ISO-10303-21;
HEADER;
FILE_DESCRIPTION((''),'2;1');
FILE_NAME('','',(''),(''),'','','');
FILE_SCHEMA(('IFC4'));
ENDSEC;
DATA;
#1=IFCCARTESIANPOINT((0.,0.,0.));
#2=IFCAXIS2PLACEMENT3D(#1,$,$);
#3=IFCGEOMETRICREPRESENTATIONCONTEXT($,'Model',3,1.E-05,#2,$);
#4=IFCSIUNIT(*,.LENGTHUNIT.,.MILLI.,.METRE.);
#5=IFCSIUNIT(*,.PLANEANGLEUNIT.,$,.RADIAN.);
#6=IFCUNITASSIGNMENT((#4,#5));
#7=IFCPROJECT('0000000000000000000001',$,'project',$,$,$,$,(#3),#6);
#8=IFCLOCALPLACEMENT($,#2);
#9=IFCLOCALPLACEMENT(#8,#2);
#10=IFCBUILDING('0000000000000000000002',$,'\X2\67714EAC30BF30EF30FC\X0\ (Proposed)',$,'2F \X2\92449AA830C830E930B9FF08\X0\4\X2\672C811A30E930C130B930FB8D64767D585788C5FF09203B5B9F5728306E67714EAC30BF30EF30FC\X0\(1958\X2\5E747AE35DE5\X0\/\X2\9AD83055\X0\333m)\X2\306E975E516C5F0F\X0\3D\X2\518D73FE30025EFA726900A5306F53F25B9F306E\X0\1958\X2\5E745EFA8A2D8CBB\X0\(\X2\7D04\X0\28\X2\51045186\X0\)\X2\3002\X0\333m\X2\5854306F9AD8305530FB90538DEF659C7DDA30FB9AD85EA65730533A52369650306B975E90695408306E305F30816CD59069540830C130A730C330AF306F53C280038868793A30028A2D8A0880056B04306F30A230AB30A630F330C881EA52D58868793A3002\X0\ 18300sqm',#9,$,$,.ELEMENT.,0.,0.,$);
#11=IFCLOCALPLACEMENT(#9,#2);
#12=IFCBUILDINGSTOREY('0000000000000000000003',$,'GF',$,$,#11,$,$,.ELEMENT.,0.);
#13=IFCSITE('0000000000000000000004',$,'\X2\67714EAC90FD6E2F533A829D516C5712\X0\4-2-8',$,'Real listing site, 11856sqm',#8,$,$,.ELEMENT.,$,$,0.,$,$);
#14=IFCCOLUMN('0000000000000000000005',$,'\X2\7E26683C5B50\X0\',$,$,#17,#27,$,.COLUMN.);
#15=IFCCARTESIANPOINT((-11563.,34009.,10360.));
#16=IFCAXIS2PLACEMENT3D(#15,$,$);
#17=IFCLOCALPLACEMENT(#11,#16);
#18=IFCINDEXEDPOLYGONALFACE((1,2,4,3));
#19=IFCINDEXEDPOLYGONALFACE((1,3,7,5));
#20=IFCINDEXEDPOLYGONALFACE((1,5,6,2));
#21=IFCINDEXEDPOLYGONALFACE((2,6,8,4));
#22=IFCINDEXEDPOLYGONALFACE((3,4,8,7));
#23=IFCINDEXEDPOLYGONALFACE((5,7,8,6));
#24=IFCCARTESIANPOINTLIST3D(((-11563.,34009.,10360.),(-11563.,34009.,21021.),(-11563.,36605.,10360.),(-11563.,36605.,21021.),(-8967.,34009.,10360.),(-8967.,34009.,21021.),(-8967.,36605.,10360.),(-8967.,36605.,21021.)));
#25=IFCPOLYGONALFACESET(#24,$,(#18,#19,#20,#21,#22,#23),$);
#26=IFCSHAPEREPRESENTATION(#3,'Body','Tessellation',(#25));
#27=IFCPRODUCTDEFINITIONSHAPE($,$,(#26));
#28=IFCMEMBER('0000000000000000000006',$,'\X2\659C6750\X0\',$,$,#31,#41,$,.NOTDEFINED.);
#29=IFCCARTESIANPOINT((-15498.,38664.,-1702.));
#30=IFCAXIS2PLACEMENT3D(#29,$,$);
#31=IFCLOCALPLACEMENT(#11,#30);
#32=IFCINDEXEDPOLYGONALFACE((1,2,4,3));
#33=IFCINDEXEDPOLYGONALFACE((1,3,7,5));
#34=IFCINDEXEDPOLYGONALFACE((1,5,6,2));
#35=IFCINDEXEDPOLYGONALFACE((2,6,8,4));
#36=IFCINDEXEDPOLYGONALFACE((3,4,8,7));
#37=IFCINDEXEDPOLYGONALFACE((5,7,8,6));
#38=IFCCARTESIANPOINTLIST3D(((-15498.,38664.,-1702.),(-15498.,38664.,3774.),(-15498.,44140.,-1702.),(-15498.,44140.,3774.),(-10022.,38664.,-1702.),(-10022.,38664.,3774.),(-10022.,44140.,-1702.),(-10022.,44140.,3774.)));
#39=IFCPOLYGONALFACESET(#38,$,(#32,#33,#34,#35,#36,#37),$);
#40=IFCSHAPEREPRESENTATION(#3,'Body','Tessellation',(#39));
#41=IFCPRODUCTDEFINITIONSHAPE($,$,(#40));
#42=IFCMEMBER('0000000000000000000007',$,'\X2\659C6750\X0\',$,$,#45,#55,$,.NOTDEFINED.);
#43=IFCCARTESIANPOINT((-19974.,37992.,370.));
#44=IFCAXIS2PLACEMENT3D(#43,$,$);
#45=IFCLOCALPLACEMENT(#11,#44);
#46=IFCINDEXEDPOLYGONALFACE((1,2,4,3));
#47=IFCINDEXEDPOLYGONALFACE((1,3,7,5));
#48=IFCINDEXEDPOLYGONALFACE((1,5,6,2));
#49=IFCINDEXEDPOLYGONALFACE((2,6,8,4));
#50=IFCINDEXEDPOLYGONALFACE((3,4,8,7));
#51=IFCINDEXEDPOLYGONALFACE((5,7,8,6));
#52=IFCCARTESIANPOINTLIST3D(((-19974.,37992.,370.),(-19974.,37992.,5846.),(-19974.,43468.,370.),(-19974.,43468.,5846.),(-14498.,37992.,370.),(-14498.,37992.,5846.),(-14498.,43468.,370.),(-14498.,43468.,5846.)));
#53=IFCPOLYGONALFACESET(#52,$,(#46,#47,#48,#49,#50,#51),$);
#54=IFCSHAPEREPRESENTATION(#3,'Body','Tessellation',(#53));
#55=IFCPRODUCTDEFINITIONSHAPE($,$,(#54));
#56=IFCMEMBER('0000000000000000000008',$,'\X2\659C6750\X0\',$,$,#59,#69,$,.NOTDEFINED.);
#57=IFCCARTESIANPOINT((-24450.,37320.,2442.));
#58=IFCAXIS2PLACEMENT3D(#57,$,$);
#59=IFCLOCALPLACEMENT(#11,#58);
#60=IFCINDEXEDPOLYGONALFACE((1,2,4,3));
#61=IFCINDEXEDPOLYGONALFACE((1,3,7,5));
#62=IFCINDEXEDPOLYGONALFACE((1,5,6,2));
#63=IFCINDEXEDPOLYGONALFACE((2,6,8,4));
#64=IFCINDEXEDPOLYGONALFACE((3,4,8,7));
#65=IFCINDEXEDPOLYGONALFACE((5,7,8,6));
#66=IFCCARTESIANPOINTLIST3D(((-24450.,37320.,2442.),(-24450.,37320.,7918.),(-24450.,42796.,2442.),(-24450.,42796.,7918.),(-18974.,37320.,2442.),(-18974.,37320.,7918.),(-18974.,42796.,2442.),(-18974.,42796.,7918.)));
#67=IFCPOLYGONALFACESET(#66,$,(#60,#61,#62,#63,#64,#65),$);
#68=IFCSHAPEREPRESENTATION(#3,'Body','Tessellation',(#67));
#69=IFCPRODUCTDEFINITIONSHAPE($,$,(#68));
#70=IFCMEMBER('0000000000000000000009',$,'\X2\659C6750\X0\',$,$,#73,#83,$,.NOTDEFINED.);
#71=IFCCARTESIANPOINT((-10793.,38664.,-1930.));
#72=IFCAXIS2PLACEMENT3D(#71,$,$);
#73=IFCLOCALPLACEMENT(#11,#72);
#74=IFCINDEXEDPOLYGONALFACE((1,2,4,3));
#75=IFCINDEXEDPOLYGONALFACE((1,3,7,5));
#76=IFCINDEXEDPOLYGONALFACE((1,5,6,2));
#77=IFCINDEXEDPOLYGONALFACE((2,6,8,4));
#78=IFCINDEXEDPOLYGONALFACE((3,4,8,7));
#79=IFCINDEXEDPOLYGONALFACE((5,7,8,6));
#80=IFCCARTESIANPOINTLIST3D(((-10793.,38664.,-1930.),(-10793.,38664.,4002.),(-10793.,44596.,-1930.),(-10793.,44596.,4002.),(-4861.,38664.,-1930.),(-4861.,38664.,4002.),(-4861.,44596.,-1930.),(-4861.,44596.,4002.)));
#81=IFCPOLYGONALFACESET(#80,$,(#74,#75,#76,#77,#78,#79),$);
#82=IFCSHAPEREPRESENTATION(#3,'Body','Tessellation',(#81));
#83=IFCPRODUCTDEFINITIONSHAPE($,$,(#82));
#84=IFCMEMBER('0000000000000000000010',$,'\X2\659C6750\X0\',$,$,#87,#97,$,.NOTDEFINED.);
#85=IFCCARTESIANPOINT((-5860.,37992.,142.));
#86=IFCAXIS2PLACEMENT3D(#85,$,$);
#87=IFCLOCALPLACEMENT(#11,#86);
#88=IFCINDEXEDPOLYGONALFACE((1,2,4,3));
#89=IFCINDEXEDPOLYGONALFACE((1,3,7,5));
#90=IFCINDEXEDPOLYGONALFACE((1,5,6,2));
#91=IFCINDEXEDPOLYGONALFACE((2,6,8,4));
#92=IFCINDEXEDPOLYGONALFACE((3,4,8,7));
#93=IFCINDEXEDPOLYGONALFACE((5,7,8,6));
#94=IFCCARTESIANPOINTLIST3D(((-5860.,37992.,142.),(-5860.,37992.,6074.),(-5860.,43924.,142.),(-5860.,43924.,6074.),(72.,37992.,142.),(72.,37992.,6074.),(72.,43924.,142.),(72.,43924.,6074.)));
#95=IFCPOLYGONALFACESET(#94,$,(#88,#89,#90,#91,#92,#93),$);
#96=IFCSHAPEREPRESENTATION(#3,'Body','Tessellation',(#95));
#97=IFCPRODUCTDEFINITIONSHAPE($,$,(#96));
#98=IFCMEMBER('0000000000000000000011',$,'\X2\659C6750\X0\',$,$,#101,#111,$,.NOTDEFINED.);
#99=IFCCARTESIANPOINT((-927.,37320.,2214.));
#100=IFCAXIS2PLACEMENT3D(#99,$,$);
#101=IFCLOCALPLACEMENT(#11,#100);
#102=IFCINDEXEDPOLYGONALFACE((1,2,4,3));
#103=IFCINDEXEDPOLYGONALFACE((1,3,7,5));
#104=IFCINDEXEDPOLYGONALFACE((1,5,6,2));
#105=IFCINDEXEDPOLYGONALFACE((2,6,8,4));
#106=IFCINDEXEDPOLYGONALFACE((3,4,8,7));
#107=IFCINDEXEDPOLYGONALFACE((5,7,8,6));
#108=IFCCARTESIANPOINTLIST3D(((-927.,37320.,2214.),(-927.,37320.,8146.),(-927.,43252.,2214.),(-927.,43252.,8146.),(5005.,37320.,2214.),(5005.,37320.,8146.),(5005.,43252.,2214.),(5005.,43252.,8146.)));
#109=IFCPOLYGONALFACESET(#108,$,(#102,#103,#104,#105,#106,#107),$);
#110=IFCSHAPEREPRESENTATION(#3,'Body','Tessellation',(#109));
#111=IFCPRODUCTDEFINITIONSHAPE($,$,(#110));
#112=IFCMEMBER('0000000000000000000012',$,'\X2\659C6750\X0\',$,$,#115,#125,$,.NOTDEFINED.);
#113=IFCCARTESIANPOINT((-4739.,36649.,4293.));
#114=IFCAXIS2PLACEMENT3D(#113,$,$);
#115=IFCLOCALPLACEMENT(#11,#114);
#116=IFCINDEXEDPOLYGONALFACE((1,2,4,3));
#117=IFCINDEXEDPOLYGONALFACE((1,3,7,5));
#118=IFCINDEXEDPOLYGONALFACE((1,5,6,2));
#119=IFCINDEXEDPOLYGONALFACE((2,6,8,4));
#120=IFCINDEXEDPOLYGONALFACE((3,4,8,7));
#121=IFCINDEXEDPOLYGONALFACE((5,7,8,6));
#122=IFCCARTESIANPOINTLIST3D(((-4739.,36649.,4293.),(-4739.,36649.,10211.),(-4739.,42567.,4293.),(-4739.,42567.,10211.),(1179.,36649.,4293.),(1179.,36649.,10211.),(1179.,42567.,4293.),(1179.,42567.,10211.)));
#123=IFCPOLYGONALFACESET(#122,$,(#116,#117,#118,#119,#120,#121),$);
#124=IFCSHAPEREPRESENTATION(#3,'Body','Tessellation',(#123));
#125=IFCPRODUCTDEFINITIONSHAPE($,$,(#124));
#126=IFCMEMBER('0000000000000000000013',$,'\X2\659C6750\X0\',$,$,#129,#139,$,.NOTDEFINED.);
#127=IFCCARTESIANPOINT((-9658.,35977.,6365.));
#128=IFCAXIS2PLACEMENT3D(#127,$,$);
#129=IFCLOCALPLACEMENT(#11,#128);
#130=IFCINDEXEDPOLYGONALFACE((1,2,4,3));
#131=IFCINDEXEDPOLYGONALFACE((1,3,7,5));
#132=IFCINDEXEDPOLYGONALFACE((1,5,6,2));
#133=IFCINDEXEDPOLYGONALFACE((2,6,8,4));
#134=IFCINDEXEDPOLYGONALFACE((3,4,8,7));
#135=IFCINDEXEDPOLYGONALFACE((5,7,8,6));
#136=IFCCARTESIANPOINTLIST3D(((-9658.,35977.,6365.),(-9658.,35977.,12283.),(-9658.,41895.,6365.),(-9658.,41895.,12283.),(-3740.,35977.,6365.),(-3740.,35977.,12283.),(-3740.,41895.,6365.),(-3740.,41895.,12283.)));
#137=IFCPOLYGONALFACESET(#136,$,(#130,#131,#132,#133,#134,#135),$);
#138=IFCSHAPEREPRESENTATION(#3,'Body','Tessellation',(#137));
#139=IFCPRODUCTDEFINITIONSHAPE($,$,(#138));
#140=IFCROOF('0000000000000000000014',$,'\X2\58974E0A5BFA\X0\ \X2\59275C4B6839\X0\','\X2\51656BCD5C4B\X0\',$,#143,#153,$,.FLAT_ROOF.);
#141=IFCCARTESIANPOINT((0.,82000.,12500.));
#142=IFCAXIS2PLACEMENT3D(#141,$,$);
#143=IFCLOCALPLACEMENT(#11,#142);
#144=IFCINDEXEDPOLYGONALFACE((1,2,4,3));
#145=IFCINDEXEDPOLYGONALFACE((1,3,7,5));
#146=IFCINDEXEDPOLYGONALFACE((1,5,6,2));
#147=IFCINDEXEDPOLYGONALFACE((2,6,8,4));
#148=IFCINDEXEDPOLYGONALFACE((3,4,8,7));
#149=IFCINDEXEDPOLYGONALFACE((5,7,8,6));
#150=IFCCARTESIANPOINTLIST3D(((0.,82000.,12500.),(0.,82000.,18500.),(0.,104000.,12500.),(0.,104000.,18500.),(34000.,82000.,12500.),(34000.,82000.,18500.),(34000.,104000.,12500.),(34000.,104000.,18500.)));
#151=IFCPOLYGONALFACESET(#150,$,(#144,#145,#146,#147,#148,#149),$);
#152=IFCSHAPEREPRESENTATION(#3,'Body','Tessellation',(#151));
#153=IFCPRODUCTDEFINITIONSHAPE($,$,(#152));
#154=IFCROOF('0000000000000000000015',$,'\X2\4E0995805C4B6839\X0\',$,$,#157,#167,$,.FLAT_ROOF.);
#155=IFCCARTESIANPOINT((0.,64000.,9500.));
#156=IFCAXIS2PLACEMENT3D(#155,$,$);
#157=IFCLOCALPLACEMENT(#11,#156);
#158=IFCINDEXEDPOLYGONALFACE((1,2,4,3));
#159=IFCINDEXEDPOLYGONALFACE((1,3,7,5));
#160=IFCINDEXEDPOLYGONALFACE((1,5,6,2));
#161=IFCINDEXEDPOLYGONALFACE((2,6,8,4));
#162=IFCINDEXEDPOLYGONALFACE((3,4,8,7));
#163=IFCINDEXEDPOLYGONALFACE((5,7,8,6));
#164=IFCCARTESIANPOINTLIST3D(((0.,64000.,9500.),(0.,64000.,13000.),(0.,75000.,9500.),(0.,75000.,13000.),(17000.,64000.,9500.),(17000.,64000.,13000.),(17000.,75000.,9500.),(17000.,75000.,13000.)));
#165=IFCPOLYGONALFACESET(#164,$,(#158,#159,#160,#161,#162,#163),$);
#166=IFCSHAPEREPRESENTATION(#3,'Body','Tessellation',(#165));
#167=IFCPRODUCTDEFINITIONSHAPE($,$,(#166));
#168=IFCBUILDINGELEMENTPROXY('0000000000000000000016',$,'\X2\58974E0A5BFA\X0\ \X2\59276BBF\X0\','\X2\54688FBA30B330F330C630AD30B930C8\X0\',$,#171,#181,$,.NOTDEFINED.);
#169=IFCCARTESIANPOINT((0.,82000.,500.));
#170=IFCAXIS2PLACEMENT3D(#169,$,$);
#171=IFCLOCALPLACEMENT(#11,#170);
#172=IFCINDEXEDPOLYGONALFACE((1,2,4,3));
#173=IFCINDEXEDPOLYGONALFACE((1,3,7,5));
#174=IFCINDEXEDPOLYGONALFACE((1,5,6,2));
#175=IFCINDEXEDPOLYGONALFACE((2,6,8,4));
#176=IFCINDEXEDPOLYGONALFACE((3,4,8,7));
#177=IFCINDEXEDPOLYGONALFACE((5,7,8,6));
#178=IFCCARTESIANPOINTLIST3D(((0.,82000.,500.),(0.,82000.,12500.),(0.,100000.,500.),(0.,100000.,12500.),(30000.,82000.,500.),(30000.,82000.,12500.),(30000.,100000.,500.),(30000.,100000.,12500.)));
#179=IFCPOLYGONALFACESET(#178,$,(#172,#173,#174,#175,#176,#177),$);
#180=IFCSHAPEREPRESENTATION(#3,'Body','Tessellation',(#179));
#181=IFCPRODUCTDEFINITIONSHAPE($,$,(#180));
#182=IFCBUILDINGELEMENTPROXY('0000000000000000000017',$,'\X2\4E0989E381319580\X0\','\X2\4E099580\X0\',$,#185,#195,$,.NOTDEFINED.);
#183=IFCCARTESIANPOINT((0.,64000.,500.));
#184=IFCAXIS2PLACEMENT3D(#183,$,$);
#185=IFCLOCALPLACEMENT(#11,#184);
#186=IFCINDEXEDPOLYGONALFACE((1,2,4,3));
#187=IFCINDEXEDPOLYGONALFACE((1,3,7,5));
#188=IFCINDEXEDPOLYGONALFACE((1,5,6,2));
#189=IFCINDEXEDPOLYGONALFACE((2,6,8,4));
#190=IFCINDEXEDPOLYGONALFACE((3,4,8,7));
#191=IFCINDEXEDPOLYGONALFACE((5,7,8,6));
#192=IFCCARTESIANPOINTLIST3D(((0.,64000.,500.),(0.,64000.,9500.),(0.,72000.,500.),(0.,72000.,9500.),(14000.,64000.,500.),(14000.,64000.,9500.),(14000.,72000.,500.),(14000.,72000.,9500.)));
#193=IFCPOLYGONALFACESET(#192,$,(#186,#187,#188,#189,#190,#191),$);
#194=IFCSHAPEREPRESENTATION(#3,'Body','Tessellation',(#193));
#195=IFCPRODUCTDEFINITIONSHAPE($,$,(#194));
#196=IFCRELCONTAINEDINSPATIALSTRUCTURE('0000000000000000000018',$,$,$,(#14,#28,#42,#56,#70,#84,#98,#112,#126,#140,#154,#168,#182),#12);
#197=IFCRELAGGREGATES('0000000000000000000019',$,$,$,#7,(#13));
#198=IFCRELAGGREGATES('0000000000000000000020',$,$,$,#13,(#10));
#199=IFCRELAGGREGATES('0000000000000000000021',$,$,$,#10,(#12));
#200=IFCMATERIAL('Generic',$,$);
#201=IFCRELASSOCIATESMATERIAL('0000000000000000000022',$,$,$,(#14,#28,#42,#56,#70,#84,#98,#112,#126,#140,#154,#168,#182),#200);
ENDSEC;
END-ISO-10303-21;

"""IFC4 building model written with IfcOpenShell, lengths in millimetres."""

from ifc_helpers import new_model, si_unit, frame, frame_2d, origin, place, context, project, spatial, rectangle, extrude, material, element, save


model = new_model("IFC4")

# Units and contexts
model_context = context("Model", 3, precision=1e-05, world=origin())
ifc_project = project(units=[si_unit("LENGTHUNIT", "METRE", prefix="MILLI"), si_unit("PLANEANGLEUNIT", "RADIAN")], contexts=[model_context])

# Site, building, storey
site_placement = place(None, origin())
site = spatial("IfcSite", under=ifc_project, at=site_placement, Name="東京都港区芝公園4-2-8", ObjectType="Real listing site, 11856sqm", CompositionType="ELEMENT", RefElevation=0.0)
building_placement = place(site_placement, origin())
building = spatial("IfcBuilding", under=site, at=building_placement, Name="東京タワー (Proposed)", ObjectType="2F 鉄骨トラス（4本脚ラチス・赤白塗装）※実在の東京タワー(1958年竣工/高さ333m)の非公式3D再現。建物¥は史実の1958年建設費(約28億円)。333m塔は高さ・道路斜線・高度地区制限に非適合のため法適合チェックは参考表示。設計者欄はアカウント自動表示。 18300sqm", CompositionType="ELEMENT", ElevationOfRefHeight=0.0, ElevationOfTerrain=0.0)
storey_placement = place(building_placement, origin())
storey = spatial("IfcBuildingStorey", under=building, at=storey_placement, Name="GF", CompositionType="ELEMENT", Elevation=0.0)

# Column
ifc_material = material(Name="Generic")
column_1_placement = place(storey_placement, frame((-11563.0, 34009.0, 10360.0)))
element("IfcColumn", 1, at=column_1_placement, inside=storey, material=ifc_material, Name="縦格子", PredefinedType="COLUMN", context=model_context, shape_type="SweptSolid", body=[
    extrude(rectangle(XDim=2596.0, YDim=2596.0, at=frame_2d((1298.0, 1298.0))), frame((-11563.0, 34009.0, 10360.0)), (0.0, 0.0, 1.0), 10661.0),
])

# Members
member_1_placement = place(storey_placement, frame((-15498.0, 38664.0, -1702.0)))
element("IfcMember", 2, at=member_1_placement, inside=storey, material=ifc_material, Name="斜材", PredefinedType="NOTDEFINED", context=model_context, shape_type="SweptSolid", body=[
    extrude(rectangle(XDim=5476.0, YDim=5476.0, at=frame_2d((2738.0, 2738.0))), frame((-15498.0, 38664.0, -1702.0)), (0.0, 0.0, 1.0), 5476.0),
])
member_2_placement = place(storey_placement, frame((-19974.0, 37992.0, 370.0)))
element("IfcMember", 3, at=member_2_placement, inside=storey, material=ifc_material, Name="斜材", PredefinedType="NOTDEFINED", context=model_context, shape_type="SweptSolid", body=[
    extrude(rectangle(XDim=5476.0, YDim=5476.0, at=frame_2d((2738.0, 2738.0))), frame((-19974.0, 37992.0, 370.0)), (0.0, 0.0, 1.0), 5476.0),
])
member_3_placement = place(storey_placement, frame((-24450.0, 37320.0, 2442.0)))
element("IfcMember", 4, at=member_3_placement, inside=storey, material=ifc_material, Name="斜材", PredefinedType="NOTDEFINED", context=model_context, shape_type="SweptSolid", body=[
    extrude(rectangle(XDim=5476.0, YDim=5476.0, at=frame_2d((2738.0, 2738.0))), frame((-24450.0, 37320.0, 2442.0)), (0.0, 0.0, 1.0), 5476.0),
])
member_4_placement = place(storey_placement, frame((-10793.0, 38664.0, -1930.0)))
element("IfcMember", 5, at=member_4_placement, inside=storey, material=ifc_material, Name="斜材", PredefinedType="NOTDEFINED", context=model_context, shape_type="SweptSolid", body=[
    extrude(rectangle(XDim=5932.0, YDim=5932.0, at=frame_2d((2966.0, 2966.0))), frame((-10793.0, 38664.0, -1930.0)), (0.0, 0.0, 1.0), 5932.0),
])
member_5_placement = place(storey_placement, frame((-5860.0, 37992.0, 142.0)))
element("IfcMember", 6, at=member_5_placement, inside=storey, material=ifc_material, Name="斜材", PredefinedType="NOTDEFINED", context=model_context, shape_type="SweptSolid", body=[
    extrude(rectangle(XDim=5932.0, YDim=5932.0, at=frame_2d((2966.0, 2966.0))), frame((-5860.0, 37992.0, 142.0)), (0.0, 0.0, 1.0), 5932.0),
])
member_6_placement = place(storey_placement, frame((-927.0, 37320.0, 2214.0)))
element("IfcMember", 7, at=member_6_placement, inside=storey, material=ifc_material, Name="斜材", PredefinedType="NOTDEFINED", context=model_context, shape_type="SweptSolid", body=[
    extrude(rectangle(XDim=5932.0, YDim=5932.0, at=frame_2d((2966.0, 2966.0))), frame((-927.0, 37320.0, 2214.0)), (0.0, 0.0, 1.0), 5932.0),
])
member_7_placement = place(storey_placement, frame((-4739.0, 36649.0, 4293.0)))
element("IfcMember", 8, at=member_7_placement, inside=storey, material=ifc_material, Name="斜材", PredefinedType="NOTDEFINED", context=model_context, shape_type="SweptSolid", body=[
    extrude(rectangle(XDim=5918.0, YDim=5918.0, at=frame_2d((2959.0, 2959.0))), frame((-4739.0, 36649.0, 4293.0)), (0.0, 0.0, 1.0), 5918.0),
])
member_8_placement = place(storey_placement, frame((-9658.0, 35977.0, 6365.0)))
element("IfcMember", 9, at=member_8_placement, inside=storey, material=ifc_material, Name="斜材", PredefinedType="NOTDEFINED", context=model_context, shape_type="SweptSolid", body=[
    extrude(rectangle(XDim=5918.0, YDim=5918.0, at=frame_2d((2959.0, 2959.0))), frame((-9658.0, 35977.0, 6365.0)), (0.0, 0.0, 1.0), 5918.0),
])

# Roofs
roof_1_placement = place(storey_placement, frame((0.0, 82000.0, 12500.0)))
element("IfcRoof", 10, at=roof_1_placement, inside=storey, material=ifc_material, Name="増上寺 大屋根", Description="入母屋", PredefinedType="FLAT_ROOF", context=model_context, shape_type="SweptSolid", body=[
    extrude(rectangle(XDim=34000.0, YDim=22000.0, at=frame_2d((17000.0, 11000.0))), frame((0.0, 82000.0, 12500.0)), (0.0, 0.0, 1.0), 6000.0),
])
roof_2_placement = place(storey_placement, frame((0.0, 64000.0, 9500.0)))
element("IfcRoof", 11, at=roof_2_placement, inside=storey, material=ifc_material, Name="三門屋根", PredefinedType="FLAT_ROOF", context=model_context, shape_type="SweptSolid", body=[
    extrude(rectangle(XDim=17000.0, YDim=11000.0, at=frame_2d((8500.0, 5500.0))), frame((0.0, 64000.0, 9500.0)), (0.0, 0.0, 1.0), 3500.0),
])

# Building element proxies
proxy_1_placement = place(storey_placement, frame((0.0, 82000.0, 500.0)))
element("IfcBuildingElementProxy", 12, at=proxy_1_placement, inside=storey, material=ifc_material, Name="増上寺 大殿", Description="周辺コンテキスト", PredefinedType="NOTDEFINED", context=model_context, shape_type="SweptSolid", body=[
    extrude(rectangle(XDim=30000.0, YDim=18000.0, at=frame_2d((15000.0, 9000.0))), frame((0.0, 82000.0, 500.0)), (0.0, 0.0, 1.0), 12000.0),
])
proxy_2_placement = place(storey_placement, frame((0.0, 64000.0, 500.0)))
element("IfcBuildingElementProxy", 13, at=proxy_2_placement, inside=storey, material=ifc_material, Name="三解脱門", Description="三門", PredefinedType="NOTDEFINED", context=model_context, shape_type="SweptSolid", body=[
    extrude(rectangle(XDim=14000.0, YDim=8000.0, at=frame_2d((7000.0, 4000.0))), frame((0.0, 64000.0, 500.0)), (0.0, 0.0, 1.0), 9000.0),
])

save(model, "model.ifc")
